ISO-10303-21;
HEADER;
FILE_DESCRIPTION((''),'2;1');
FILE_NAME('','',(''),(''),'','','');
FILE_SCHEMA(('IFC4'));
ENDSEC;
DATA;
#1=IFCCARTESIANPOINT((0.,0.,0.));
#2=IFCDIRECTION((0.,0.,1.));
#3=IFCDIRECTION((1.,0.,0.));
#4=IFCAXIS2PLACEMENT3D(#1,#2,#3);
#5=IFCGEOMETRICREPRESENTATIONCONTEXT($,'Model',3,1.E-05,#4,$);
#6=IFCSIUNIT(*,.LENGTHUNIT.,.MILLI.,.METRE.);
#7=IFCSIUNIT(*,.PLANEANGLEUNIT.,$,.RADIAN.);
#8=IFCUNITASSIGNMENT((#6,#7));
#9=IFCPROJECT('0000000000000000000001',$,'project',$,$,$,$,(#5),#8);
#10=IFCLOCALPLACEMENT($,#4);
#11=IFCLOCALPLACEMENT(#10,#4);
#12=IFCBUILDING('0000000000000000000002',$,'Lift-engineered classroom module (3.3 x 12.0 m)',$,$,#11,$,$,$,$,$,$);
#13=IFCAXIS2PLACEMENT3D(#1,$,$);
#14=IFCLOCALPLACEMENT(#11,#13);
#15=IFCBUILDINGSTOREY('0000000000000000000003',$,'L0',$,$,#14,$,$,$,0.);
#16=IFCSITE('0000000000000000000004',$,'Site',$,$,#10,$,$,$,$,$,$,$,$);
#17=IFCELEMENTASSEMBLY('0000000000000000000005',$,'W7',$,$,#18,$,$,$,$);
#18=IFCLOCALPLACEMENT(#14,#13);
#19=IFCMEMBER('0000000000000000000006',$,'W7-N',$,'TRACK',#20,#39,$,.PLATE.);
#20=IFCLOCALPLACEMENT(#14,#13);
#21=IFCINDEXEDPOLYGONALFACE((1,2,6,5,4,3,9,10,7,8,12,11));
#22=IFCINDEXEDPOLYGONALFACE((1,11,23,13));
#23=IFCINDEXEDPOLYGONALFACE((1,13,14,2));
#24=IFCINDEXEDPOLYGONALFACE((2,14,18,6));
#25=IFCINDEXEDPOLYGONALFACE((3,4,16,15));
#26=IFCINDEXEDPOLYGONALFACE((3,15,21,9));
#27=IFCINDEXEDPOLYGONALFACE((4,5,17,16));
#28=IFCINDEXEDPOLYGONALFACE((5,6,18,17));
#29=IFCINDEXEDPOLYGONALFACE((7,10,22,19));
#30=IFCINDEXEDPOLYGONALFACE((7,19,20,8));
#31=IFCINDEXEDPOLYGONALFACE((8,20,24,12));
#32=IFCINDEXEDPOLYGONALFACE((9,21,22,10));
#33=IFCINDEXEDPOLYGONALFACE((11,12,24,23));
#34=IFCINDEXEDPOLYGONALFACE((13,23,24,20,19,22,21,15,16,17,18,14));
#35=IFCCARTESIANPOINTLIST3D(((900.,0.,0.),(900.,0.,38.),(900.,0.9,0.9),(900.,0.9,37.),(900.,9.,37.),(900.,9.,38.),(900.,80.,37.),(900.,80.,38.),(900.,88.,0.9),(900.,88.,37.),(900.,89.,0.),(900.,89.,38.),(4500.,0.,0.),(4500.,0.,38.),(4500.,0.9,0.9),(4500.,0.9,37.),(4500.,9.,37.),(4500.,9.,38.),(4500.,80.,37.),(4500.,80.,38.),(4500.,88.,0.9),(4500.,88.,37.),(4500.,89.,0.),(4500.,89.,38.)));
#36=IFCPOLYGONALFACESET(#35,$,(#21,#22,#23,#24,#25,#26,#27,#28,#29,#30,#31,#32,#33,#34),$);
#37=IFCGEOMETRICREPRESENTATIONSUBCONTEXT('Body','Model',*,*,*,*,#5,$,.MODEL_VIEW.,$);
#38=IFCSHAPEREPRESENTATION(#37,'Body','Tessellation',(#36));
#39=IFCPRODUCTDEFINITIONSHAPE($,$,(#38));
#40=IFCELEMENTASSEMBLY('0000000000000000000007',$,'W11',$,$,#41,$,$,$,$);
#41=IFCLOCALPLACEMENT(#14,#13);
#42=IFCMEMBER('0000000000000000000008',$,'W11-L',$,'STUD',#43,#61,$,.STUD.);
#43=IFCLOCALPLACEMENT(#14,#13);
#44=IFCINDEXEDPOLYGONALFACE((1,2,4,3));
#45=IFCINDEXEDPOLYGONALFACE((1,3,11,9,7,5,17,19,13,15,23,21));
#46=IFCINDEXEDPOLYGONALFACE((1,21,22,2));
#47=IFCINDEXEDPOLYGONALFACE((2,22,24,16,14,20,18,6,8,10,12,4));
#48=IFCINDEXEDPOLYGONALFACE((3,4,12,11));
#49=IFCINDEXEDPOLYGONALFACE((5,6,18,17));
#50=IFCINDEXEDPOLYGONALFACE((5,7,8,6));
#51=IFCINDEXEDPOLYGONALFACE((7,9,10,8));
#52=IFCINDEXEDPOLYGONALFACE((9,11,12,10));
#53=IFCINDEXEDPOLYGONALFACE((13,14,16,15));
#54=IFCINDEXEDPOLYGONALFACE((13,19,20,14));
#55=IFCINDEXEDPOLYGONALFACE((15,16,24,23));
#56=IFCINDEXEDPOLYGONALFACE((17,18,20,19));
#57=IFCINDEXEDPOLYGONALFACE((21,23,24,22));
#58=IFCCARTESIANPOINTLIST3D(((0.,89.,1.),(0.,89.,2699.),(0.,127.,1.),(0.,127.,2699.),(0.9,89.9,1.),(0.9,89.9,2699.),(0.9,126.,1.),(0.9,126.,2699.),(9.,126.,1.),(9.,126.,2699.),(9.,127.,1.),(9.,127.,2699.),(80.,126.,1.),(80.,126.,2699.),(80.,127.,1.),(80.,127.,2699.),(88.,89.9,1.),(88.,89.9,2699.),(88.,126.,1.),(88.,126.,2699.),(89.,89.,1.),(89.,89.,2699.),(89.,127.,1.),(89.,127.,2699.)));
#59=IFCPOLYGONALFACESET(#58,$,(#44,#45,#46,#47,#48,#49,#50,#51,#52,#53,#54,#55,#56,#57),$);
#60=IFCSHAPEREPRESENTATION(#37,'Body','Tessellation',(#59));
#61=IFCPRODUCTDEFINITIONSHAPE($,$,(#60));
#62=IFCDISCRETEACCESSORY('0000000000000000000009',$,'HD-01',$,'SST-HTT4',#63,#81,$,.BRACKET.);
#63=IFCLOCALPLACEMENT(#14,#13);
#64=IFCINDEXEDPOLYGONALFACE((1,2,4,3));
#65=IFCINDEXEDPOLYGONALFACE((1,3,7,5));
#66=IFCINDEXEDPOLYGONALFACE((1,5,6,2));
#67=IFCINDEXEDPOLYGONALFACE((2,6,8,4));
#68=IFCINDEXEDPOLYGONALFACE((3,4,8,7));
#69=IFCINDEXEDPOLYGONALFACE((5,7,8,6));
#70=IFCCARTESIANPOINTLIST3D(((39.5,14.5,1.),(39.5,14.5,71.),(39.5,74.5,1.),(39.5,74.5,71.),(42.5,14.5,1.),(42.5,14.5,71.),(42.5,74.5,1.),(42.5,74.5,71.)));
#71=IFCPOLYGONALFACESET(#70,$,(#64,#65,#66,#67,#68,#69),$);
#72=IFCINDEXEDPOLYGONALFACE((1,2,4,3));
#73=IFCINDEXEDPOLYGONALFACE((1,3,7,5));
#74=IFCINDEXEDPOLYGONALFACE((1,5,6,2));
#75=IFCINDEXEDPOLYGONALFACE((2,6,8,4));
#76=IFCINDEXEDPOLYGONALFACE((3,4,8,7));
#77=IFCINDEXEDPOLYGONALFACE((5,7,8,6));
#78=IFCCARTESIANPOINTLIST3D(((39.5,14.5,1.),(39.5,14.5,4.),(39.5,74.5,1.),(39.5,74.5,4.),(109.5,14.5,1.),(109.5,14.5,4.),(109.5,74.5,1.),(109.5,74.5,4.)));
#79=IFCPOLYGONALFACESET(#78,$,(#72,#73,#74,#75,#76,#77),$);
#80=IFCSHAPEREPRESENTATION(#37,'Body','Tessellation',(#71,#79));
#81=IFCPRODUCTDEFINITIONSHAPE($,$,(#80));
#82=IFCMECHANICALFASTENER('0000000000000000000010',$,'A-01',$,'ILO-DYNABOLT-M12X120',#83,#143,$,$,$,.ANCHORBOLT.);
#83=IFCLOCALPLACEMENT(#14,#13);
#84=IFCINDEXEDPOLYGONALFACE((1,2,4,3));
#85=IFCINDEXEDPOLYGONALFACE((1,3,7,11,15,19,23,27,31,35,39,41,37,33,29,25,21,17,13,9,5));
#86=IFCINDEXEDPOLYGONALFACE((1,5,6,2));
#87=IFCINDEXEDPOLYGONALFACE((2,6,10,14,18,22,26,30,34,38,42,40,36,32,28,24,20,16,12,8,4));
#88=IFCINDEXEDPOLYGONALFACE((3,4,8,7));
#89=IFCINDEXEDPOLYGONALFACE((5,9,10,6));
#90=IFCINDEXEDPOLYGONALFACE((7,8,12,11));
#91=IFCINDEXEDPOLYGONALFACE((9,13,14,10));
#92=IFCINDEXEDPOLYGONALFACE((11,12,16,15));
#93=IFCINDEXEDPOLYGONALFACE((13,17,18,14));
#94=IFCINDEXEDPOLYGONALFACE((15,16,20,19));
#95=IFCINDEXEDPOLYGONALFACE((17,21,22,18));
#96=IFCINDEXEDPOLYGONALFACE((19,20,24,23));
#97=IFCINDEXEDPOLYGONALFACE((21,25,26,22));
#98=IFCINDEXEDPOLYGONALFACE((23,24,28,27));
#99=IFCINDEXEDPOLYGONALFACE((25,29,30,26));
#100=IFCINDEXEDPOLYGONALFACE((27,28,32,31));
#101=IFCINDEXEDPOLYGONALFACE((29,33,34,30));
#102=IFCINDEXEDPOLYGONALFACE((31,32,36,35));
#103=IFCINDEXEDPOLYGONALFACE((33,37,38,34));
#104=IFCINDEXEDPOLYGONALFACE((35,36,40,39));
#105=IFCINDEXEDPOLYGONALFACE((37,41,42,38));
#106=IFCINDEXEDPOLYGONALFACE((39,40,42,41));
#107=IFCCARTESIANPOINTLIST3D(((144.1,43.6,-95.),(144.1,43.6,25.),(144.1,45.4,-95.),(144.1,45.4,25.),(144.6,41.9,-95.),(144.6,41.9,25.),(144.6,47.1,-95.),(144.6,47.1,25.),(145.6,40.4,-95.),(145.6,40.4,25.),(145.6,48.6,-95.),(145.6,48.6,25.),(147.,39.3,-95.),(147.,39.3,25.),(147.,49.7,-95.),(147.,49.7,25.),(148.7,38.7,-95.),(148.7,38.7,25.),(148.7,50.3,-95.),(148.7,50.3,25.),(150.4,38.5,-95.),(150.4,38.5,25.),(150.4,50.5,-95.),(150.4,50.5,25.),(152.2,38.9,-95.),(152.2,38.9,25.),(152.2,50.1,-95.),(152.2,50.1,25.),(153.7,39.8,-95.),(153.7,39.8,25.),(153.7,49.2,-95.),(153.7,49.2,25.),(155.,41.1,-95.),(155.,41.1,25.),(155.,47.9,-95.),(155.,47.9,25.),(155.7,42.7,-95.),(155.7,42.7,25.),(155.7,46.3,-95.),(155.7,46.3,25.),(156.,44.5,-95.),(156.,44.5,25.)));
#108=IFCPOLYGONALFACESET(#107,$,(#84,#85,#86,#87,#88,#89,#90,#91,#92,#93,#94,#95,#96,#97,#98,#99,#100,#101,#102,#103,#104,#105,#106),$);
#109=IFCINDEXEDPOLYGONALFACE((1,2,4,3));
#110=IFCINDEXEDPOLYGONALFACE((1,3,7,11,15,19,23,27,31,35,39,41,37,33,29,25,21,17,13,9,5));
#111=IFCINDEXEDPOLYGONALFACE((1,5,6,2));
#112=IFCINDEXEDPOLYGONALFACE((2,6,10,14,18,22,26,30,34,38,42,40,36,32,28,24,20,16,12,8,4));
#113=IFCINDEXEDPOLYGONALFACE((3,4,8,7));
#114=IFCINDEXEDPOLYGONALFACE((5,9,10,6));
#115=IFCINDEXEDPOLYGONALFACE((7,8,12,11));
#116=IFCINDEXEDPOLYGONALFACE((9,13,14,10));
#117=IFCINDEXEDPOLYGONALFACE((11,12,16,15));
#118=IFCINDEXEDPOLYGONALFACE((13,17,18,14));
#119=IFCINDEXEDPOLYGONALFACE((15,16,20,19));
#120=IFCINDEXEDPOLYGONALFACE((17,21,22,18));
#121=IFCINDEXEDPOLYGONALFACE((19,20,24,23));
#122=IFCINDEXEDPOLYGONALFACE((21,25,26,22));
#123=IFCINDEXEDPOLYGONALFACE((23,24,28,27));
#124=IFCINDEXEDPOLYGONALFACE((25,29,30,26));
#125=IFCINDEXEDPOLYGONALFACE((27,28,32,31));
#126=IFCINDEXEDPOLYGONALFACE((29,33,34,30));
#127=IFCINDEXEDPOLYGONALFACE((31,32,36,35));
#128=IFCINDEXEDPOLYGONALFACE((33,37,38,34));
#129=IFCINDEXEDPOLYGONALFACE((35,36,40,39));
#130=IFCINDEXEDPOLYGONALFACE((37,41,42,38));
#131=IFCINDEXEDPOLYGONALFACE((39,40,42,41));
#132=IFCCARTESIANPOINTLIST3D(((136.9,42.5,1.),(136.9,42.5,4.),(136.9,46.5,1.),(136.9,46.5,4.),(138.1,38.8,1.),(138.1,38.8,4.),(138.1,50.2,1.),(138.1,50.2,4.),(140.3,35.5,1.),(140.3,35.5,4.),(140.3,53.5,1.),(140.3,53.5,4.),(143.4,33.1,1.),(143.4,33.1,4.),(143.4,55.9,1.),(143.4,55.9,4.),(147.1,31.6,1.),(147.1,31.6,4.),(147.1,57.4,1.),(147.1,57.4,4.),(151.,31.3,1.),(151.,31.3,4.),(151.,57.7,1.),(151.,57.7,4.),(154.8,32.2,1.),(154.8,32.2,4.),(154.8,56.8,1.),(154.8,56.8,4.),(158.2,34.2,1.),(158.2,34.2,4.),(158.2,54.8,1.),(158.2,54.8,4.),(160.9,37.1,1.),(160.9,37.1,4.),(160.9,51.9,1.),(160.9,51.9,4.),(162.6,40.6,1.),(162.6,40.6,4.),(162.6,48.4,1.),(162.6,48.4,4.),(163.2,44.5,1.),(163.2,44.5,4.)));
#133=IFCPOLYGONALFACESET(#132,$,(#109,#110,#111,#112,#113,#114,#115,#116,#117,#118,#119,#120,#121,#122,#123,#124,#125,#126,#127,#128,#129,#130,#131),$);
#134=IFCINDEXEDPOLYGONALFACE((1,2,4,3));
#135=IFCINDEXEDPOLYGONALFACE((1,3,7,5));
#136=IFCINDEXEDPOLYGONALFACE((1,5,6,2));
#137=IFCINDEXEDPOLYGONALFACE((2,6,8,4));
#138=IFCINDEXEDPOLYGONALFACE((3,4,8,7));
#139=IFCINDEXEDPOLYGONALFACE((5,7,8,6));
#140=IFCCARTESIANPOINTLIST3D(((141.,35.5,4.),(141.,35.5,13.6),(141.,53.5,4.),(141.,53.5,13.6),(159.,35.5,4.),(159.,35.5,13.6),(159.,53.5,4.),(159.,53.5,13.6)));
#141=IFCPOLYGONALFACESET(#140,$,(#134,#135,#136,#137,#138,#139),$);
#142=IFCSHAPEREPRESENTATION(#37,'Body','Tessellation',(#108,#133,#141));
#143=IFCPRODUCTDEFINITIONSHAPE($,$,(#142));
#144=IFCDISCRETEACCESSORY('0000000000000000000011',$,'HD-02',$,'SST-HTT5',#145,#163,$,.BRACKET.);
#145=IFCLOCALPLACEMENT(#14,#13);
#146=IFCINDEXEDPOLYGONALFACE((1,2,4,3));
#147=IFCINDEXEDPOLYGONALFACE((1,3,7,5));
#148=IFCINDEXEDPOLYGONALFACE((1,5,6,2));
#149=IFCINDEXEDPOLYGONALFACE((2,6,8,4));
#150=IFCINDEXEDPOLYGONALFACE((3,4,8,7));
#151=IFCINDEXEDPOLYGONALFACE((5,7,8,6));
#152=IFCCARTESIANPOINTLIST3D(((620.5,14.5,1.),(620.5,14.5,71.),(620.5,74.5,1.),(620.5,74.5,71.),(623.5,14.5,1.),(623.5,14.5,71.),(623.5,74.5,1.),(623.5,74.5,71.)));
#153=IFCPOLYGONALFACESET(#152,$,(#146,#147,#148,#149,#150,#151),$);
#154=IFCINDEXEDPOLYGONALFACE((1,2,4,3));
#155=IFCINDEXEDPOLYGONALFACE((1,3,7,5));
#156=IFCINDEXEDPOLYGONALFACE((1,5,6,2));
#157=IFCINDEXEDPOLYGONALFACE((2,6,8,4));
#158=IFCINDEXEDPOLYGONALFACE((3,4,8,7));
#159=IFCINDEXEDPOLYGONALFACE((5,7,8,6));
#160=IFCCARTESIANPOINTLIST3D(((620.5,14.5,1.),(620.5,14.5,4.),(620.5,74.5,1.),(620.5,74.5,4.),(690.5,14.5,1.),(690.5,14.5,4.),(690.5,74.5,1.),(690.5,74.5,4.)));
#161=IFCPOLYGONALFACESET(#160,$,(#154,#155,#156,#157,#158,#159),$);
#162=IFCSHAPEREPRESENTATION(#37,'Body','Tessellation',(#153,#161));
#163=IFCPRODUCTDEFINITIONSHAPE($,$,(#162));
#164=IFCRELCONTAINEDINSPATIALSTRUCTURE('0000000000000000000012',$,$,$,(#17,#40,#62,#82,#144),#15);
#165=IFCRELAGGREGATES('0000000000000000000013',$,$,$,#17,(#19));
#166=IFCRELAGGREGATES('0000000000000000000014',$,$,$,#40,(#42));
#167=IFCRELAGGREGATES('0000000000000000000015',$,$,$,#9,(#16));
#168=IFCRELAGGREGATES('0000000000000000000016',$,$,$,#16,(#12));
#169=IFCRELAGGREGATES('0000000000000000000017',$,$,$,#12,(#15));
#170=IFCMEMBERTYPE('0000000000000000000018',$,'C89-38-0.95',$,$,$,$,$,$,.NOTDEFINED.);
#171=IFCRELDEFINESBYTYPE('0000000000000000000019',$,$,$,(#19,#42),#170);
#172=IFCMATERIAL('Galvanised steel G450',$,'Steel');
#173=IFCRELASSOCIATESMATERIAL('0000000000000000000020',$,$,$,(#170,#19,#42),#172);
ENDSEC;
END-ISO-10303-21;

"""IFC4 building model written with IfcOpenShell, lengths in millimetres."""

from ifc_helpers import new_model, si_unit, frame, frame_2d, origin, origin_with_axes, origin_2d, place, context, subcontext, project, spatial, rectangle, circle, c_section, extrude, material, material_profile, profile_set, profile_usage, type_object, element, aggregate, save


model = new_model("IFC4")

# Units and contexts
model_context = context("Model", 3, precision=1e-05, world=origin_with_axes())
body_context = subcontext(model_context, "Body", "Model", "MODEL_VIEW")
ifc_project = project(units=[si_unit("LENGTHUNIT", "METRE", prefix="MILLI"), si_unit("PLANEANGLEUNIT", "RADIAN")], contexts=[model_context])

# Site, building, storey
site_placement = place(None, origin_with_axes())
site = spatial("IfcSite", under=ifc_project, at=site_placement, Name="Site")
building_placement = place(site_placement, origin_with_axes())
building = spatial("IfcBuilding", under=site, at=building_placement, Name="Lift-engineered classroom module (3.3 x 12.0 m)")
storey_placement = place(building_placement, origin())
storey = spatial("IfcBuildingStorey", under=building, at=storey_placement, Name="L0", Elevation=0.0)

# Element assembly, member
ifc_material = material(Name="Galvanised steel G450", Category="Steel")
ifc_material_profile = material_profile(ifc_material, c_section(Depth=89.0, Width=38.0, WallThickness=0.9, Girth=9.0, at=origin_2d()), Name="C89-38-0.95")
ifc_profile_set = profile_set([ifc_material_profile], Name="C89-38-0.95")
ifc_profile_usage = profile_usage(ifc_profile_set)
member_type = type_object("IfcMemberType", Name="C89-38-0.95", PredefinedType="NOTDEFINED", material=ifc_profile_set)
assembly_1_placement = place(storey_placement, frame((900.0, 44.5, 0.0)))
assembly_1 = element("IfcElementAssembly", 1, at=assembly_1_placement, inside=storey, Name="W7")
member_1_placement = place(assembly_1_placement, frame((0.0, 0.0, 19.0), z_axis=(1.0, 0.0, 0.0), x_axis=(0.0, 0.0, 1.0)))
member_1 = element("IfcMember", 2, at=member_1_placement, type_object=member_type, material=ifc_profile_usage, Name="W7-N", ObjectType="TRACK", PredefinedType="PLATE", context=body_context, shape_type="SweptSolid", body=[
    extrude(c_section(Depth=89.0, Width=38.0, WallThickness=0.9, Girth=9.0, at=origin_2d()), origin(), (0.0, 0.0, 1.0), 3600.0),
])
aggregate(assembly_1, [member_1])

# Element assembly, member
assembly_2_placement = place(storey_placement, frame((44.5, 3211.0, 0.0)))
assembly_2 = element("IfcElementAssembly", 3, at=assembly_2_placement, inside=storey, Name="W11")
member_2_placement = place(assembly_2_placement, frame((0.0, -3103.0, 0.9), z_axis=(0.0, 0.0, 1.0), x_axis=(0.0, 1.0, 0.0)))
member_2 = element("IfcMember", 4, at=member_2_placement, type_object=member_type, material=ifc_profile_usage, Name="W11-L", ObjectType="STUD", PredefinedType="STUD", context=body_context, shape_type="SweptSolid", body=[
    extrude(c_section(Depth=89.0, Width=38.0, WallThickness=0.9, Girth=9.0, at=origin_2d()), origin(), (0.0, 0.0, 1.0), 2698.1),
])
aggregate(assembly_2, [member_2])

# Discrete accessory
discrete_accessory_1_placement = place(None, frame((39.5, 44.5, 0.0), z_axis=(0.0, 0.0, 1.0), x_axis=(1.0, 0.0, 0.0)))
element("IfcDiscreteAccessory", 5, at=discrete_accessory_1_placement, inside=storey, Name="HD-01", ObjectType="SST-HTT4", PredefinedType="BRACKET", context=body_context, shape_type="SweptSolid", body=[
    extrude(rectangle(XDim=3.0, YDim=60.0, at=frame_2d((1.5, 0.0))), frame((0.0, 0.0, 1.0), z_axis=(0.0, 0.0, 1.0), x_axis=(1.0, 0.0, 0.0)), (0.0, 0.0, 1.0), 70.0),
    extrude(rectangle(XDim=70.0, YDim=60.0, at=frame_2d((35.0, 0.0))), frame((0.0, 0.0, 1.0), z_axis=(0.0, 0.0, 1.0), x_axis=(1.0, 0.0, 0.0)), (0.0, 0.0, 1.0), 3.0),
])

# Mechanical fastener
mechanical_fastener_1_placement = place(None, frame((150.0, 44.5, 0.0), z_axis=(0.0, 0.0, 1.0), x_axis=(1.0, 0.0, 0.0)))
element("IfcMechanicalFastener", 6, at=mechanical_fastener_1_placement, inside=storey, Name="A-01", ObjectType="ILO-DYNABOLT-M12X120", PredefinedType="ANCHORBOLT", context=body_context, shape_type="SweptSolid", body=[
    extrude(circle(Radius=6.0, at=origin_2d()), frame((0.0, 0.0, -95.0), z_axis=(0.0, 0.0, 1.0), x_axis=(1.0, 0.0, 0.0)), (0.0, 0.0, 1.0), 120.0),
    extrude(circle(Radius=13.2, at=origin_2d()), frame((0.0, 0.0, 1.0), z_axis=(0.0, 0.0, 1.0), x_axis=(1.0, 0.0, 0.0)), (0.0, 0.0, 1.0), 3.0),
    extrude(rectangle(XDim=18.0, YDim=18.0, at=origin_2d()), frame((0.0, 0.0, 4.0), z_axis=(0.0, 0.0, 1.0), x_axis=(1.0, 0.0, 0.0)), (0.0, 0.0, 1.0), 9.6),
])

# Discrete accessory
discrete_accessory_2_placement = place(None, frame((620.5, 44.5, 0.0), z_axis=(0.0, 0.0, 1.0), x_axis=(1.0, 0.0, 0.0)))
element("IfcDiscreteAccessory", 7, at=discrete_accessory_2_placement, inside=storey, Name="HD-02", ObjectType="SST-HTT5", PredefinedType="BRACKET", context=body_context, shape_type="SweptSolid", body=[
    extrude(rectangle(XDim=3.0, YDim=60.0, at=frame_2d((1.5, 0.0))), frame((0.0, 0.0, 1.0), z_axis=(0.0, 0.0, 1.0), x_axis=(1.0, 0.0, 0.0)), (0.0, 0.0, 1.0), 70.0),
    extrude(rectangle(XDim=70.0, YDim=60.0, at=frame_2d((35.0, 0.0))), frame((0.0, 0.0, 1.0), z_axis=(0.0, 0.0, 1.0), x_axis=(1.0, 0.0, 0.0)), (0.0, 0.0, 1.0), 3.0),
])

save(model, "model.ifc")
